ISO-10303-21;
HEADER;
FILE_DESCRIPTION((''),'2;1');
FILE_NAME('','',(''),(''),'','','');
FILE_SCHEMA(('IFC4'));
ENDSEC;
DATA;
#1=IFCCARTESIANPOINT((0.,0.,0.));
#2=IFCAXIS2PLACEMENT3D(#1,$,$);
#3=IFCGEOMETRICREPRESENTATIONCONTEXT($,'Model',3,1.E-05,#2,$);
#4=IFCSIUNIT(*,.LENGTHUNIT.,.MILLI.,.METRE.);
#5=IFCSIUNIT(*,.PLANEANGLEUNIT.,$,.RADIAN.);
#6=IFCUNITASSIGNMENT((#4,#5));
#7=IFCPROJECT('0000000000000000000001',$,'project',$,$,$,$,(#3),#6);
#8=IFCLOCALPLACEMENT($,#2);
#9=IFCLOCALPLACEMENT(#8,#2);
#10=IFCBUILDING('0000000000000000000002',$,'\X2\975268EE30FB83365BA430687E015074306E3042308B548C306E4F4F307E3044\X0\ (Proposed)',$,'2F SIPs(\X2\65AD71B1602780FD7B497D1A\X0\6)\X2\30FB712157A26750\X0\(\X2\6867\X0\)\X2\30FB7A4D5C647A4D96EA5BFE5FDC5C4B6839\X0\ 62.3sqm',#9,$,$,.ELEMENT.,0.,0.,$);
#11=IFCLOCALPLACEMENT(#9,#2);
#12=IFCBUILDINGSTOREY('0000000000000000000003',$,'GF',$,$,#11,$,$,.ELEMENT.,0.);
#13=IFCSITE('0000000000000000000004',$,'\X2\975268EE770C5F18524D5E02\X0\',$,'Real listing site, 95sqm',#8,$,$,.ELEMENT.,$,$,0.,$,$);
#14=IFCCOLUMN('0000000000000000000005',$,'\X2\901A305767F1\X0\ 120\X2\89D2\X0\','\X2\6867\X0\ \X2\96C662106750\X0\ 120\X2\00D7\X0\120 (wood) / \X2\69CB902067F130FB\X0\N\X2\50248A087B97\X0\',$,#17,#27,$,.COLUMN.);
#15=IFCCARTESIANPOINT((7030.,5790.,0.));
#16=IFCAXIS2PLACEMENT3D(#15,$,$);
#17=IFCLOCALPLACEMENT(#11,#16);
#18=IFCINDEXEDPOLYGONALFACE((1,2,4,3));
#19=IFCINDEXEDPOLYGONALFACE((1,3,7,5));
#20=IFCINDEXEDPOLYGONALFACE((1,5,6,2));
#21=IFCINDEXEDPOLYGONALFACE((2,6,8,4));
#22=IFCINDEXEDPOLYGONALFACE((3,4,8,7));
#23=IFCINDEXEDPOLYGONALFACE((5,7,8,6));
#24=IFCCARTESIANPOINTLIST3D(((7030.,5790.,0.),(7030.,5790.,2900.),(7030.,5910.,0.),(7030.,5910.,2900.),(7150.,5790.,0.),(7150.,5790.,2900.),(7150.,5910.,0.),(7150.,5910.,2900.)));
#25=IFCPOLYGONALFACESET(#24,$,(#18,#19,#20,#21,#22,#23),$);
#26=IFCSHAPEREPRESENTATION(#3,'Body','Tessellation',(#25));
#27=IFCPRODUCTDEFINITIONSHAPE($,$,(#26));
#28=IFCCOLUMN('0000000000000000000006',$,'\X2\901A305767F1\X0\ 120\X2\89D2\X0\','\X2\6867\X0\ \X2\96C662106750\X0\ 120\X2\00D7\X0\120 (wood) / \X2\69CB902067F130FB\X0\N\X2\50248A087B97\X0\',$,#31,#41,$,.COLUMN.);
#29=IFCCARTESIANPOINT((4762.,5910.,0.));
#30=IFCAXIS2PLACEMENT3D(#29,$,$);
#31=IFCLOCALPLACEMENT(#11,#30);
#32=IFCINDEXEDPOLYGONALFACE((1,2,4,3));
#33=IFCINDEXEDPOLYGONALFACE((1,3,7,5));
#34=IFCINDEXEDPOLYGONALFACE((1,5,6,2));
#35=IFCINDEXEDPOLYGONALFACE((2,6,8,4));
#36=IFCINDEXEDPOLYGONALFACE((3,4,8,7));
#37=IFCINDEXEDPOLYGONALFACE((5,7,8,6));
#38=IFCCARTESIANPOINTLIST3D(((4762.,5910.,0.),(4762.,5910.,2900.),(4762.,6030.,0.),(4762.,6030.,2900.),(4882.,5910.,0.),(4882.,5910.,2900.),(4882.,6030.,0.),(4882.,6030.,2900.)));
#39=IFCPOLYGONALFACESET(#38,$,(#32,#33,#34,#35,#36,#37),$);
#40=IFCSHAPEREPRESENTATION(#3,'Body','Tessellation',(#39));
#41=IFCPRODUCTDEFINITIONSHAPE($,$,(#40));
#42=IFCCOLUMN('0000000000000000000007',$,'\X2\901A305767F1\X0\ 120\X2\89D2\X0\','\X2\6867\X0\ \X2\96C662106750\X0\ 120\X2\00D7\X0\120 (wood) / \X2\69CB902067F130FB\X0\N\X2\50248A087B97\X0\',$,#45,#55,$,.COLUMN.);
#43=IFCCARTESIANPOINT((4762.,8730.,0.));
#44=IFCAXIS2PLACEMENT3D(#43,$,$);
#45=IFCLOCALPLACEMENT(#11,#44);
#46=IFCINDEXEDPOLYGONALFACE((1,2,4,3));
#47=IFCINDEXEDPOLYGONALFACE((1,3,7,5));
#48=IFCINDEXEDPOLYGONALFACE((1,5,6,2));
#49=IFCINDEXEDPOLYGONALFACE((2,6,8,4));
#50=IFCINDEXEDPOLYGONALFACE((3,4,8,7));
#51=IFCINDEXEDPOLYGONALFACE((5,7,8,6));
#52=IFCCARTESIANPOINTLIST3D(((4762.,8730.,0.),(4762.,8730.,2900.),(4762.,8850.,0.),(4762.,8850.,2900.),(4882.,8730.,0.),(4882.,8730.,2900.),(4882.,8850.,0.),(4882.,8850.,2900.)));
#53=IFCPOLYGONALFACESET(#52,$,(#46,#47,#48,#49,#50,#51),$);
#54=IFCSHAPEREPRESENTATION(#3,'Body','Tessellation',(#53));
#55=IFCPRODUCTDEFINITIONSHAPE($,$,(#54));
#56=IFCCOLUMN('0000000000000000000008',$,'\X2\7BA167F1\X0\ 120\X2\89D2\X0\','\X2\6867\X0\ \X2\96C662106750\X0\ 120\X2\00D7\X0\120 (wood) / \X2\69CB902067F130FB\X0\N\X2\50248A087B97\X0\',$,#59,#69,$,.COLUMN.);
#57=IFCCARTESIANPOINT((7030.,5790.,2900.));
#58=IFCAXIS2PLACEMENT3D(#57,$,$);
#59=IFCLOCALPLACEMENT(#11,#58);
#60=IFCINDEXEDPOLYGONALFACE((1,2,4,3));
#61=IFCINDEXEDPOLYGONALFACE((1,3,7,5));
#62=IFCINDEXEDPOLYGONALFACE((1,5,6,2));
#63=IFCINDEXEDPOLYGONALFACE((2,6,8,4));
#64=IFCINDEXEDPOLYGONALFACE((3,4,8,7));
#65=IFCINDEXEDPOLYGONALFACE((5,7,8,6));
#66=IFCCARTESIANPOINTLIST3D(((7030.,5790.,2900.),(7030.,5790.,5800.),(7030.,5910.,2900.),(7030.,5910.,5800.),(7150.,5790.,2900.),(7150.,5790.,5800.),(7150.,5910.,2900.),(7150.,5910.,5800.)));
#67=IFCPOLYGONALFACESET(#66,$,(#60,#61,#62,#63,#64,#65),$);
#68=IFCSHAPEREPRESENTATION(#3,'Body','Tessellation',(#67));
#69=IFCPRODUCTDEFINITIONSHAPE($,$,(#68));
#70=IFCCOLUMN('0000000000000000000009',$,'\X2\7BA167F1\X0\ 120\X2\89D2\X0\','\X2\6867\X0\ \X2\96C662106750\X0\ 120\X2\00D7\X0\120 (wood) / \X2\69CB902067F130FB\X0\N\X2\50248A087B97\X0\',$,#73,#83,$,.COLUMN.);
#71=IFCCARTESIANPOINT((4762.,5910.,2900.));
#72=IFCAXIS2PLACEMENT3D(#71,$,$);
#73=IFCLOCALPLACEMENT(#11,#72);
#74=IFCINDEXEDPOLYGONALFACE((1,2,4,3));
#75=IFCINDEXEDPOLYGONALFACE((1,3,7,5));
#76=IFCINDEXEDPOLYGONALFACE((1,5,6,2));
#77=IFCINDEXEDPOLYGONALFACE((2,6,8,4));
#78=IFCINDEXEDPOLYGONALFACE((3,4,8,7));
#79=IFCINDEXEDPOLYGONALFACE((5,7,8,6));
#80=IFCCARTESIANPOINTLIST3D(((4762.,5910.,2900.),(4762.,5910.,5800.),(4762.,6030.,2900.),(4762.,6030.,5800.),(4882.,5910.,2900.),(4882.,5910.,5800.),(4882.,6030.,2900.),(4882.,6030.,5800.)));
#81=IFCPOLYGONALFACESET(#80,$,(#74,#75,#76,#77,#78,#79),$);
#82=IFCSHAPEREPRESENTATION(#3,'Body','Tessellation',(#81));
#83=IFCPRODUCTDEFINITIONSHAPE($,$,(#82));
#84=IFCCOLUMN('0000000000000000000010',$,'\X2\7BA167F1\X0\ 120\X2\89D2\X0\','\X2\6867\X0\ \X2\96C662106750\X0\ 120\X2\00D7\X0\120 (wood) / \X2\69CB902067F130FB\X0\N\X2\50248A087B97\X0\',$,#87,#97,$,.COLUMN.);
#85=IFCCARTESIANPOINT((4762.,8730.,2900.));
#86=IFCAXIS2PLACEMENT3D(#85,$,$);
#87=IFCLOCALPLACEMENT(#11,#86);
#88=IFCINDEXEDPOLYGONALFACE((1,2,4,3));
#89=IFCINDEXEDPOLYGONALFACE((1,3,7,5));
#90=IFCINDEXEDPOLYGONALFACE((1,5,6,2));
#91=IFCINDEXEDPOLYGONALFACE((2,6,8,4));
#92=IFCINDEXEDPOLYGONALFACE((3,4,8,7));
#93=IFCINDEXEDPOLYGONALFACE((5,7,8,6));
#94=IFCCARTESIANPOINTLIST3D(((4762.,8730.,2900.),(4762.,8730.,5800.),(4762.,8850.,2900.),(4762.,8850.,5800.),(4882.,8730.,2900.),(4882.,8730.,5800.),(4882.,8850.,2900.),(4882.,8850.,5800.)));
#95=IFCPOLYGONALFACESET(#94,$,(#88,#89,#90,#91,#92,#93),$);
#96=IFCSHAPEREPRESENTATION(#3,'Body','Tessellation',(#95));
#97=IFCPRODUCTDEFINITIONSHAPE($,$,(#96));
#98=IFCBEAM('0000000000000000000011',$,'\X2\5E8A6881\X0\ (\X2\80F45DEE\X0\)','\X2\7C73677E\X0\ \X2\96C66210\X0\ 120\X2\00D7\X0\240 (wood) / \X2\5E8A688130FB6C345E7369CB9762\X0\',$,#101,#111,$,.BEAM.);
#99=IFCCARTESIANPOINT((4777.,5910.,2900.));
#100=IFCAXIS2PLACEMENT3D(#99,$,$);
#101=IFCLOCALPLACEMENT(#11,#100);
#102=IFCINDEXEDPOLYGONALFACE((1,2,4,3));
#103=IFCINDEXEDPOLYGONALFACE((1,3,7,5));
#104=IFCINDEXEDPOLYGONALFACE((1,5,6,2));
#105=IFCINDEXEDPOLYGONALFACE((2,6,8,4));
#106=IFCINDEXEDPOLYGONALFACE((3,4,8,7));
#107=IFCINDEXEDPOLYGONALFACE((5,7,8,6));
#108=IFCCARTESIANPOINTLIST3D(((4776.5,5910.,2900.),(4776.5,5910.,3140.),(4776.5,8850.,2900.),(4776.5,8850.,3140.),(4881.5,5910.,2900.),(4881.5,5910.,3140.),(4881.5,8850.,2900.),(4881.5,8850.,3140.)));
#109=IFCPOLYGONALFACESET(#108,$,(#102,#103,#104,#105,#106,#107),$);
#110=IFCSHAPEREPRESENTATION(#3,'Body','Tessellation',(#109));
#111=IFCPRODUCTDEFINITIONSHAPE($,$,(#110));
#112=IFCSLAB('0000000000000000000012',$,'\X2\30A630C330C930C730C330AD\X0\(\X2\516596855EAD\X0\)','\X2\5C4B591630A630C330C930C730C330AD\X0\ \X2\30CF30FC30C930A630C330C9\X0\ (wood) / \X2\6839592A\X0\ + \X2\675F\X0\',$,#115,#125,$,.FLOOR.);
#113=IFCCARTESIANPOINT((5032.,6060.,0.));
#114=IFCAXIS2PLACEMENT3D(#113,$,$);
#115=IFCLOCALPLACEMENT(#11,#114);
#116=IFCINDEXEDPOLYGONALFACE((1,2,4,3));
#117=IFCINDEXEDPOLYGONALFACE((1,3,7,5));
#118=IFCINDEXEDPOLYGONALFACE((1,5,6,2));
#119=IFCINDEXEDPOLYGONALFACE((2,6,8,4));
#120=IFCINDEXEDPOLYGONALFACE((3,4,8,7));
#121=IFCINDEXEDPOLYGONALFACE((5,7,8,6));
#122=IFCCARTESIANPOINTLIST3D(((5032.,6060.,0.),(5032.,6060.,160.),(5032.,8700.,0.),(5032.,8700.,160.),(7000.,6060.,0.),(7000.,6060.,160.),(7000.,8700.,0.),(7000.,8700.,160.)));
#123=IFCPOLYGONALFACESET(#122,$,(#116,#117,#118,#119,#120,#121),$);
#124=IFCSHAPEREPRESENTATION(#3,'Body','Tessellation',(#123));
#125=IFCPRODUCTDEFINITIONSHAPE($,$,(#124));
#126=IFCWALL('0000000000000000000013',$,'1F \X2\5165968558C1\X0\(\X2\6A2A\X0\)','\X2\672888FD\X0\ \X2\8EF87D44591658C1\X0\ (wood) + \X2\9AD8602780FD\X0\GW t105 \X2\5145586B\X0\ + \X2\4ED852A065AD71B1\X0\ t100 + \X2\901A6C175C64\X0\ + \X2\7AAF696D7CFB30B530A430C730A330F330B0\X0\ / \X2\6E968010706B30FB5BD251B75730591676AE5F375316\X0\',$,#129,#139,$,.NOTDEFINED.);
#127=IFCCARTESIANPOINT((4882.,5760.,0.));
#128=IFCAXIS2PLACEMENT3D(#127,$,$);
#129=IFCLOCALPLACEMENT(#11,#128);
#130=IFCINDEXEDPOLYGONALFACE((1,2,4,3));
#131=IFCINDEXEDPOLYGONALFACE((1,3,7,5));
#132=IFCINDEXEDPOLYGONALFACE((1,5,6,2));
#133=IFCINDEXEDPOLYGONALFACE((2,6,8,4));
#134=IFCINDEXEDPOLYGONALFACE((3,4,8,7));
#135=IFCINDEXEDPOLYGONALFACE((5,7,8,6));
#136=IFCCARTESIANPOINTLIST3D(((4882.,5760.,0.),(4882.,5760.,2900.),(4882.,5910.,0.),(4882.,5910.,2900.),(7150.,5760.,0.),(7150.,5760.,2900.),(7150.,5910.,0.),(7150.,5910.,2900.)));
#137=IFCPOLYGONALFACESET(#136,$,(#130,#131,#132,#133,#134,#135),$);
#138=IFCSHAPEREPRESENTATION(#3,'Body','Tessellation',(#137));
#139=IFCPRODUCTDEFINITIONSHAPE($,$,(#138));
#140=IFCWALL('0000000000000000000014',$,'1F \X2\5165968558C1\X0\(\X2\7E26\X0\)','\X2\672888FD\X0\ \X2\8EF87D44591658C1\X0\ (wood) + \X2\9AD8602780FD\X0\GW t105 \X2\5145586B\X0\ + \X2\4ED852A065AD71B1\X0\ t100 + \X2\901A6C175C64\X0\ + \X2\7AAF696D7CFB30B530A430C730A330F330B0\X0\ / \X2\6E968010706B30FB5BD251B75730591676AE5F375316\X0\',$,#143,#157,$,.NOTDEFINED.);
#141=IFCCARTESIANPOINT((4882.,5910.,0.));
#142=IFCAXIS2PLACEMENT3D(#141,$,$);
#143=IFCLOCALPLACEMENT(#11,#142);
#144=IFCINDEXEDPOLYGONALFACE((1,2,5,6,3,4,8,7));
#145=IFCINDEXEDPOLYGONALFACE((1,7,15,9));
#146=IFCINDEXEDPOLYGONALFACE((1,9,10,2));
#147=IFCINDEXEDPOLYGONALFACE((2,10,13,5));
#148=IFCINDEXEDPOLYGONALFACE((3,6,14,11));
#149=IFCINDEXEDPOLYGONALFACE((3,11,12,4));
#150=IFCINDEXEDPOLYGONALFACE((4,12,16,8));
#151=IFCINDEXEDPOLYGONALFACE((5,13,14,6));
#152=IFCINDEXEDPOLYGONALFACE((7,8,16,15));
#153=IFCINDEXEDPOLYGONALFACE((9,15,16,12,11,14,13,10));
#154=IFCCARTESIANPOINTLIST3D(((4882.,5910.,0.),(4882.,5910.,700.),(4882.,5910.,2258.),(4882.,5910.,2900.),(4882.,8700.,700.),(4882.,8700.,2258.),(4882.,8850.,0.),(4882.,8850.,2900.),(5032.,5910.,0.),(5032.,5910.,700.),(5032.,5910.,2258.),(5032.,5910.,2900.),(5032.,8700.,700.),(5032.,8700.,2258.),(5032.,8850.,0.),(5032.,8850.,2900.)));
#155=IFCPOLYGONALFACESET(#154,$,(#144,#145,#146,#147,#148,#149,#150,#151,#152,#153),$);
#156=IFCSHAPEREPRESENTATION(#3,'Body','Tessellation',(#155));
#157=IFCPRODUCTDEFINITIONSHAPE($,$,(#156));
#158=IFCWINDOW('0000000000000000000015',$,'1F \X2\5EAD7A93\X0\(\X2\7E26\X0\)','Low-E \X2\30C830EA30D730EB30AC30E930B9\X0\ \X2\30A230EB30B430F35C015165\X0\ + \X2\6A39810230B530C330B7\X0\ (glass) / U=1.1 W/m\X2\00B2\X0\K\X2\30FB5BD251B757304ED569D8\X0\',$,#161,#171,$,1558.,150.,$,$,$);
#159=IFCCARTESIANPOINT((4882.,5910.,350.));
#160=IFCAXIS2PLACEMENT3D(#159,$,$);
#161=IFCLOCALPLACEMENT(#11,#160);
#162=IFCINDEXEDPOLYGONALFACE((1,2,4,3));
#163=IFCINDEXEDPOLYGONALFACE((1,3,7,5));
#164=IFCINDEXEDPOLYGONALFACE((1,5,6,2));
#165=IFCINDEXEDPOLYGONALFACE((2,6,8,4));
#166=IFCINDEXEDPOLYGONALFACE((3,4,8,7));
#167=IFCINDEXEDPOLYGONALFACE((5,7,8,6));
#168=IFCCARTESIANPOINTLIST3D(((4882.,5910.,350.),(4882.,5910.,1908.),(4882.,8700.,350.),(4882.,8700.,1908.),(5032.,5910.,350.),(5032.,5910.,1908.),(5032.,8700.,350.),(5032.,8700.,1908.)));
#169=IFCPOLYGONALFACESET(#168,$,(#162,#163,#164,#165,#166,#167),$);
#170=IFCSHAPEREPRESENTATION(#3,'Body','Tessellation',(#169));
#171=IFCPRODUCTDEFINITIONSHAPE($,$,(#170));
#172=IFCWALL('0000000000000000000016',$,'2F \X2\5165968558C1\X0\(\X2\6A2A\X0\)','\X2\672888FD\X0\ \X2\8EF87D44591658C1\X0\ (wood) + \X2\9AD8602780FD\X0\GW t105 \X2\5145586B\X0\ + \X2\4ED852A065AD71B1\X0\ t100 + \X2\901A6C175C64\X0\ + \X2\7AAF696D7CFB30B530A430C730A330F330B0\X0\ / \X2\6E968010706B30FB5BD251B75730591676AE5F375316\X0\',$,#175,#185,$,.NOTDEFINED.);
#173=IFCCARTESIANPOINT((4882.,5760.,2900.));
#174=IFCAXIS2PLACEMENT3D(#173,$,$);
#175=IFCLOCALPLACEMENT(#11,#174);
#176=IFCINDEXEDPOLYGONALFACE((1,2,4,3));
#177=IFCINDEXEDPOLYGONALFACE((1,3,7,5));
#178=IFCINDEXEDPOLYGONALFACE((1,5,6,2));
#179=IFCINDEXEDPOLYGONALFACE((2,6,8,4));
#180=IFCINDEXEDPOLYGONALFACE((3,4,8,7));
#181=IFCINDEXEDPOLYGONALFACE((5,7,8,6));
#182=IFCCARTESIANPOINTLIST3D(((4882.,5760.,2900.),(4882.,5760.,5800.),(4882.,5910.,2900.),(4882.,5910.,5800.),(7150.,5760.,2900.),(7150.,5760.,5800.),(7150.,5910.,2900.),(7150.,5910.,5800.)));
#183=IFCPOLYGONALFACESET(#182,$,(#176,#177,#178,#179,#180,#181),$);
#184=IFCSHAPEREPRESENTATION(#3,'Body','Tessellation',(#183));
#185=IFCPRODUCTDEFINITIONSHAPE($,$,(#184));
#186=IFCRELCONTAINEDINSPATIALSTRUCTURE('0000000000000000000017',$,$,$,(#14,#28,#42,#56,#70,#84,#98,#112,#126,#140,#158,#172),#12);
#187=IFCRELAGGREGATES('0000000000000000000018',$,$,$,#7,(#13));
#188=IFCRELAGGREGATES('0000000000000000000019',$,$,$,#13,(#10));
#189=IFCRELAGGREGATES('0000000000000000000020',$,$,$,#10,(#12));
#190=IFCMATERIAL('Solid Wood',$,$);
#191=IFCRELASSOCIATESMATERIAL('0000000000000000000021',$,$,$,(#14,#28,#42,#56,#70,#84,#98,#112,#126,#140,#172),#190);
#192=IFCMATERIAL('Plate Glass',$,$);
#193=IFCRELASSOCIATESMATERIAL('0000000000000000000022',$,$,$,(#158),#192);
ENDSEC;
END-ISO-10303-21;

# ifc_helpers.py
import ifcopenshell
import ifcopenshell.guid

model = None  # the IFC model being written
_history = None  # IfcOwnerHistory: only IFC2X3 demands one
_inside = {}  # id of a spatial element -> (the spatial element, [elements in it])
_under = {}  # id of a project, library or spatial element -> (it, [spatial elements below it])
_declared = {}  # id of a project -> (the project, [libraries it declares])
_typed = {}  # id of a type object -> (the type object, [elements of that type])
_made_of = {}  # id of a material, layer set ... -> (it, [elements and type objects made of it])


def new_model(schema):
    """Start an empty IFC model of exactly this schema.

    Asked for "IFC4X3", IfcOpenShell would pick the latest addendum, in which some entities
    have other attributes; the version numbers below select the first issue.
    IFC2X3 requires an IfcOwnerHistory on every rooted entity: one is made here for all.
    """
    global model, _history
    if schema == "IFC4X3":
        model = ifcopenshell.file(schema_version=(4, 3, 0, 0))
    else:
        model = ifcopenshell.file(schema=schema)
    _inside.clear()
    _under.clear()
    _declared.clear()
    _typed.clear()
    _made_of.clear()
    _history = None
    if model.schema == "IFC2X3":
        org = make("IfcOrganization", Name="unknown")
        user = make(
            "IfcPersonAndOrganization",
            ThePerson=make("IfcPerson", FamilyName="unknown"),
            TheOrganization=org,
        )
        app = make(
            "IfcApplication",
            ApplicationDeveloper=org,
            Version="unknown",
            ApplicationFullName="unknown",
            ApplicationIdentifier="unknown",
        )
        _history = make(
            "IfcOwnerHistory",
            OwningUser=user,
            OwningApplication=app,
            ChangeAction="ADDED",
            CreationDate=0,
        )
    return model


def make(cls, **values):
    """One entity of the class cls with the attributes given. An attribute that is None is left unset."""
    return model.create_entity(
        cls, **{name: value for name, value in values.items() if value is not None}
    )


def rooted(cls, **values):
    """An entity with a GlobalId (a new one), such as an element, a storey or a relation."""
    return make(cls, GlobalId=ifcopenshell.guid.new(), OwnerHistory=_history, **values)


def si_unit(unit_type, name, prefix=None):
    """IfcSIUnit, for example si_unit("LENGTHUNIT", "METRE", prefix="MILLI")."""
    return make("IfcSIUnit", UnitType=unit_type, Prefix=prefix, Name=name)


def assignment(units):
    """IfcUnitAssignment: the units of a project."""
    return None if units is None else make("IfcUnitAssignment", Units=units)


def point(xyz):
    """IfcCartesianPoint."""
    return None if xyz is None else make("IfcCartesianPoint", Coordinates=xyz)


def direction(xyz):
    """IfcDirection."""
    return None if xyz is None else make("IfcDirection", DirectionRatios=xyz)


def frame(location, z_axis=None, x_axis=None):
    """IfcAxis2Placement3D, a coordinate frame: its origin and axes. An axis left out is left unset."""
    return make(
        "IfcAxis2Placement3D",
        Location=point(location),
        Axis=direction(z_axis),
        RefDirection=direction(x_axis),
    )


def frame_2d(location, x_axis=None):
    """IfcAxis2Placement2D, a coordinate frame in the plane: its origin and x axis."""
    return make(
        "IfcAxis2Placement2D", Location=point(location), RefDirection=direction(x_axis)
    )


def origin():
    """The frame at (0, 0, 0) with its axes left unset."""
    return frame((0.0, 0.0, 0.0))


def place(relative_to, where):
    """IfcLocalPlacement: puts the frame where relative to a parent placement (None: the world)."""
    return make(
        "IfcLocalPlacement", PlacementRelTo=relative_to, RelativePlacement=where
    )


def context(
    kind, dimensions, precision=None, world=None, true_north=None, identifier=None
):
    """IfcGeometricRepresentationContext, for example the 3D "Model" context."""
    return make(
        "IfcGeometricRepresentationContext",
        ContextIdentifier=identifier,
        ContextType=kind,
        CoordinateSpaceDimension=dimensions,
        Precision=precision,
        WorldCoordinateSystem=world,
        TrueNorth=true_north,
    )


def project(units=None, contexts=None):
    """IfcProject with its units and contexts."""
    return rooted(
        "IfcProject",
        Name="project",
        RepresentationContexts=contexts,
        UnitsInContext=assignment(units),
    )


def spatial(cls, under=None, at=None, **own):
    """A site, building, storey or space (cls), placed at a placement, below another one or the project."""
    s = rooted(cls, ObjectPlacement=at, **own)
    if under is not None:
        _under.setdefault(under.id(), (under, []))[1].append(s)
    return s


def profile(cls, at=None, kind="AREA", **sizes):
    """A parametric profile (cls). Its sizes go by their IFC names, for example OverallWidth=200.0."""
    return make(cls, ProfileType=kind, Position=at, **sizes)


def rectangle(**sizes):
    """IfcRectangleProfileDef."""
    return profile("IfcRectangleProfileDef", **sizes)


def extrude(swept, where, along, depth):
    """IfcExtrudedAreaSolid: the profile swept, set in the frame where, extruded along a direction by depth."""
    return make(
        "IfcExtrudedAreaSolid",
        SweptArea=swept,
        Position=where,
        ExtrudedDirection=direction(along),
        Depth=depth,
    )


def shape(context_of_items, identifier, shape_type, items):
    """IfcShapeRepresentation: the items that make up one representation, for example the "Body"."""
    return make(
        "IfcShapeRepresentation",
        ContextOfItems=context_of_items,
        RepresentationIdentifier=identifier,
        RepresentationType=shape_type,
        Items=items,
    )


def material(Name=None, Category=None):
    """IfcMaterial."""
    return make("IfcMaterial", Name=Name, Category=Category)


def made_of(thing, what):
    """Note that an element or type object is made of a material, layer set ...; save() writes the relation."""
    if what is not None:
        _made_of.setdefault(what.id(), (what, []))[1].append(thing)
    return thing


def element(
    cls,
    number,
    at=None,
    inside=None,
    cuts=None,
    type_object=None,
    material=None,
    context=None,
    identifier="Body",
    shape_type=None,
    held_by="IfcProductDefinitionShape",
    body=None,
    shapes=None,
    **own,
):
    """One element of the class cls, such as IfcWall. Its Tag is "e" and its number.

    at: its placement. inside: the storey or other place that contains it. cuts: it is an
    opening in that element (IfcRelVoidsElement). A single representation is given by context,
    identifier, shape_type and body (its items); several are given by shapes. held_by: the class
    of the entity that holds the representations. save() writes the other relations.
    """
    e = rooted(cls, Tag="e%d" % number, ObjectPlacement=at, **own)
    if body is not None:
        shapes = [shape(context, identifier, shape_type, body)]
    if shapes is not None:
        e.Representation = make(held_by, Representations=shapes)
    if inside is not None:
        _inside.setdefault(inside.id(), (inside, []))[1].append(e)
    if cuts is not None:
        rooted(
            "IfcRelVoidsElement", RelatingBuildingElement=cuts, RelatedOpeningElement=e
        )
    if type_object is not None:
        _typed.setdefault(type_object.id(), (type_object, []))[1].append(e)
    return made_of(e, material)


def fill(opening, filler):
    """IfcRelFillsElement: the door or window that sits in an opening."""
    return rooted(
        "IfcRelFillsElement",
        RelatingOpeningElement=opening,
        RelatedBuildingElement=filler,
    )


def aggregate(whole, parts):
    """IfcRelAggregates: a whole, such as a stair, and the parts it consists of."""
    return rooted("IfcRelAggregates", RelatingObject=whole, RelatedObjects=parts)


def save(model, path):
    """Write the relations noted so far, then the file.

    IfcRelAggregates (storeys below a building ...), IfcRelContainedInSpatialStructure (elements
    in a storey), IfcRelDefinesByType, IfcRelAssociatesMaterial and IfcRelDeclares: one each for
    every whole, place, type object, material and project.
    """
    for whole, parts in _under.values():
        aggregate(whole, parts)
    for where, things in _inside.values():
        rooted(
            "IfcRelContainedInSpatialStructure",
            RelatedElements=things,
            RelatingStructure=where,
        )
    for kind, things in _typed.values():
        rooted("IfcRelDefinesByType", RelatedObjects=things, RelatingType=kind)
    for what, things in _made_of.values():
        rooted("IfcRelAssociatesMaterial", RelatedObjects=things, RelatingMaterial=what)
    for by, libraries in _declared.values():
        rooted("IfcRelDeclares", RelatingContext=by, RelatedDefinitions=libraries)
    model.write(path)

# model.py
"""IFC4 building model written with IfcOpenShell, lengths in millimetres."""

from ifc_helpers import new_model, si_unit, frame, frame_2d, origin, place, context, project, spatial, rectangle, extrude, material, element, fill, save


model = new_model("IFC4")

# Units and contexts
model_context = context("Model", 3, precision=1e-05, world=origin())
ifc_project = project(units=[si_unit("LENGTHUNIT", "METRE", prefix="MILLI"), si_unit("PLANEANGLEUNIT", "RADIAN")], contexts=[model_context])

# Site, building, storey
site_placement = place(None, origin())
site = spatial("IfcSite", under=ifc_project, at=site_placement, Name="青森県弘前市", ObjectType="Real listing site, 95sqm", CompositionType="ELEMENT", RefElevation=0.0)
building_placement = place(site_placement, origin())
building = spatial("IfcBuilding", under=site, at=building_placement, Name="青森・茶室と縁側のある和の住まい (Proposed)", ObjectType="2F SIPs(断熱性能等級6)・無垢材(桧)・積層積雪対応屋根 62.3sqm", CompositionType="ELEMENT", ElevationOfRefHeight=0.0, ElevationOfTerrain=0.0)
storey_placement = place(building_placement, origin())
storey = spatial("IfcBuildingStorey", under=building, at=storey_placement, Name="GF", CompositionType="ELEMENT", Elevation=0.0)

# Columns
ifc_material_1 = material(Name="Solid Wood")
column_1_placement = place(storey_placement, frame((7030.0, 5790.0, 0.0)))
element("IfcColumn", 1, at=column_1_placement, inside=storey, material=ifc_material_1, Name="通し柱 120角", Description="桧 集成材 120×120 (wood) / 構造柱・N値計算", PredefinedType="COLUMN", context=model_context, shape_type="SweptSolid", body=[
    extrude(rectangle(XDim=120.0, YDim=120.0, at=frame_2d((60.0, 60.0))), frame((7030.0, 5790.0, 0.0)), (0.0, 0.0, 1.0), 2900.0),
])
column_2_placement = place(storey_placement, frame((4762.0, 5910.0, 0.0)))
element("IfcColumn", 2, at=column_2_placement, inside=storey, material=ifc_material_1, Name="通し柱 120角", Description="桧 集成材 120×120 (wood) / 構造柱・N値計算", PredefinedType="COLUMN", context=model_context, shape_type="SweptSolid", body=[
    extrude(rectangle(XDim=120.0, YDim=120.0, at=frame_2d((60.0, 60.0))), frame((4762.0, 5910.0, 0.0)), (0.0, 0.0, 1.0), 2900.0),
])
column_3_placement = place(storey_placement, frame((4762.0, 8730.0, 0.0)))
element("IfcColumn", 3, at=column_3_placement, inside=storey, material=ifc_material_1, Name="通し柱 120角", Description="桧 集成材 120×120 (wood) / 構造柱・N値計算", PredefinedType="COLUMN", context=model_context, shape_type="SweptSolid", body=[
    extrude(rectangle(XDim=120.0, YDim=120.0, at=frame_2d((60.0, 60.0))), frame((4762.0, 8730.0, 0.0)), (0.0, 0.0, 1.0), 2900.0),
])
column_4_placement = place(storey_placement, frame((7030.0, 5790.0, 2900.0)))
element("IfcColumn", 4, at=column_4_placement, inside=storey, material=ifc_material_1, Name="管柱 120角", Description="桧 集成材 120×120 (wood) / 構造柱・N値計算", PredefinedType="COLUMN", context=model_context, shape_type="SweptSolid", body=[
    extrude(rectangle(XDim=120.0, YDim=120.0, at=frame_2d((60.0, 60.0))), frame((7030.0, 5790.0, 2900.0)), (0.0, 0.0, 1.0), 2900.0),
])
column_5_placement = place(storey_placement, frame((4762.0, 5910.0, 2900.0)))
element("IfcColumn", 5, at=column_5_placement, inside=storey, material=ifc_material_1, Name="管柱 120角", Description="桧 集成材 120×120 (wood) / 構造柱・N値計算", PredefinedType="COLUMN", context=model_context, shape_type="SweptSolid", body=[
    extrude(rectangle(XDim=120.0, YDim=120.0, at=frame_2d((60.0, 60.0))), frame((4762.0, 5910.0, 2900.0)), (0.0, 0.0, 1.0), 2900.0),
])
column_6_placement = place(storey_placement, frame((4762.0, 8730.0, 2900.0)))
element("IfcColumn", 6, at=column_6_placement, inside=storey, material=ifc_material_1, Name="管柱 120角", Description="桧 集成材 120×120 (wood) / 構造柱・N値計算", PredefinedType="COLUMN", context=model_context, shape_type="SweptSolid", body=[
    extrude(rectangle(XDim=120.0, YDim=120.0, at=frame_2d((60.0, 60.0))), frame((4762.0, 8730.0, 2900.0)), (0.0, 0.0, 1.0), 2900.0),
])

# Beam
beam_1_placement = place(storey_placement, frame((4777.0, 5910.0, 2900.0)))
element("IfcBeam", 7, at=beam_1_placement, inside=storey, material=ifc_material_1, Name="床梁 (胴差)", Description="米松 集成 120×240 (wood) / 床梁・水平構面", PredefinedType="BEAM", context=model_context, shape_type="SweptSolid", body=[
    extrude(rectangle(XDim=105.0, YDim=2940.0, at=frame_2d((52.0, 1470.0))), frame((4777.0, 5910.0, 2900.0)), (0.0, 0.0, 1.0), 240.0),
])

# Slab
slab_placement = place(storey_placement, frame((5032.0, 6060.0, 0.0)))
element("IfcSlab", 8, at=slab_placement, inside=storey, material=ifc_material_1, Name="ウッドデッキ(入隅庭)", Description="屋外ウッドデッキ ハードウッド (wood) / 根太 + 束", PredefinedType="FLOOR", context=model_context, shape_type="SweptSolid", body=[
    extrude(rectangle(XDim=1968.0, YDim=2640.0, at=frame_2d((984.0, 1320.0))), frame((5032.0, 6060.0, 0.0)), (0.0, 0.0, 1.0), 160.0),
])

# Wall
wall_1_placement = place(storey_placement, frame((4882.0, 5760.0, 0.0)))
element("IfcWall", 9, at=wall_1_placement, inside=storey, material=ifc_material_1, Name="1F 入隅壁(横)", Description="木製 軸組外壁 (wood) + 高性能GW t105 充填 + 付加断熱 t100 + 通気層 + 窯業系サイディング / 準耐火・寒冷地外皮強化", PredefinedType="NOTDEFINED", context=model_context, shape_type="SweptSolid", body=[
    extrude(rectangle(XDim=2268.0, YDim=150.0, at=frame_2d((1134.0, 75.0))), frame((4882.0, 5760.0, 0.0)), (0.0, 0.0, 1.0), 2900.0),
])

# Wall, opening, window
wall_2_placement = place(storey_placement, frame((4882.0, 5910.0, 0.0)))
wall_2 = element("IfcWall", 10, at=wall_2_placement, inside=storey, material=ifc_material_1, Name="1F 入隅壁(縦)", Description="木製 軸組外壁 (wood) + 高性能GW t105 充填 + 付加断熱 t100 + 通気層 + 窯業系サイディング / 準耐火・寒冷地外皮強化", PredefinedType="NOTDEFINED", context=model_context, shape_type="SweptSolid", body=[
    extrude(rectangle(XDim=150.0, YDim=2940.0, at=frame_2d((75.0, 1470.0))), frame((4882.0, 5910.0, 0.0)), (0.0, 0.0, 1.0), 2900.0),
])
opening_1_placement = place(storey_placement, frame((4882.0, 5910.0, 350.0)))
opening_1 = element("IfcOpeningElement", 11, at=opening_1_placement, cuts=wall_2, PredefinedType="NOTDEFINED", context=model_context, shape_type="SweptSolid", body=[
    extrude(rectangle(XDim=150.0, YDim=2790.0, at=frame_2d((75.0, 1395.0))), frame((4882.0, 5910.0, 350.0)), (0.0, 0.0, 1.0), 1558.0),
])
ifc_material_2 = material(Name="Plate Glass")
window_1_placement = place(storey_placement, frame((4882.0, 5910.0, 350.0)))
window_1 = element("IfcWindow", 12, at=window_1_placement, inside=storey, material=ifc_material_2, Name="1F 庭窓(縦)", Description="Low-E トリプルガラス アルゴン封入 + 樹脂サッシ (glass) / U=1.1 W/m²K・寒冷地仕様", OverallHeight=1558.0, OverallWidth=150.0, context=model_context, shape_type="SweptSolid", body=[
    extrude(rectangle(XDim=150.0, YDim=2790.0, at=frame_2d((75.0, 1395.0))), frame((4882.0, 5910.0, 350.0)), (0.0, 0.0, 1.0), 1558.0),
])
fill(opening_1, window_1)

# Wall
wall_3_placement = place(storey_placement, frame((4882.0, 5760.0, 2900.0)))
element("IfcWall", 13, at=wall_3_placement, inside=storey, material=ifc_material_1, Name="2F 入隅壁(横)", Description="木製 軸組外壁 (wood) + 高性能GW t105 充填 + 付加断熱 t100 + 通気層 + 窯業系サイディング / 準耐火・寒冷地外皮強化", PredefinedType="NOTDEFINED", context=model_context, shape_type="SweptSolid", body=[
    extrude(rectangle(XDim=2268.0, YDim=150.0, at=frame_2d((1134.0, 75.0))), frame((4882.0, 5760.0, 2900.0)), (0.0, 0.0, 1.0), 2900.0),
])

save(model, "model.ifc")
